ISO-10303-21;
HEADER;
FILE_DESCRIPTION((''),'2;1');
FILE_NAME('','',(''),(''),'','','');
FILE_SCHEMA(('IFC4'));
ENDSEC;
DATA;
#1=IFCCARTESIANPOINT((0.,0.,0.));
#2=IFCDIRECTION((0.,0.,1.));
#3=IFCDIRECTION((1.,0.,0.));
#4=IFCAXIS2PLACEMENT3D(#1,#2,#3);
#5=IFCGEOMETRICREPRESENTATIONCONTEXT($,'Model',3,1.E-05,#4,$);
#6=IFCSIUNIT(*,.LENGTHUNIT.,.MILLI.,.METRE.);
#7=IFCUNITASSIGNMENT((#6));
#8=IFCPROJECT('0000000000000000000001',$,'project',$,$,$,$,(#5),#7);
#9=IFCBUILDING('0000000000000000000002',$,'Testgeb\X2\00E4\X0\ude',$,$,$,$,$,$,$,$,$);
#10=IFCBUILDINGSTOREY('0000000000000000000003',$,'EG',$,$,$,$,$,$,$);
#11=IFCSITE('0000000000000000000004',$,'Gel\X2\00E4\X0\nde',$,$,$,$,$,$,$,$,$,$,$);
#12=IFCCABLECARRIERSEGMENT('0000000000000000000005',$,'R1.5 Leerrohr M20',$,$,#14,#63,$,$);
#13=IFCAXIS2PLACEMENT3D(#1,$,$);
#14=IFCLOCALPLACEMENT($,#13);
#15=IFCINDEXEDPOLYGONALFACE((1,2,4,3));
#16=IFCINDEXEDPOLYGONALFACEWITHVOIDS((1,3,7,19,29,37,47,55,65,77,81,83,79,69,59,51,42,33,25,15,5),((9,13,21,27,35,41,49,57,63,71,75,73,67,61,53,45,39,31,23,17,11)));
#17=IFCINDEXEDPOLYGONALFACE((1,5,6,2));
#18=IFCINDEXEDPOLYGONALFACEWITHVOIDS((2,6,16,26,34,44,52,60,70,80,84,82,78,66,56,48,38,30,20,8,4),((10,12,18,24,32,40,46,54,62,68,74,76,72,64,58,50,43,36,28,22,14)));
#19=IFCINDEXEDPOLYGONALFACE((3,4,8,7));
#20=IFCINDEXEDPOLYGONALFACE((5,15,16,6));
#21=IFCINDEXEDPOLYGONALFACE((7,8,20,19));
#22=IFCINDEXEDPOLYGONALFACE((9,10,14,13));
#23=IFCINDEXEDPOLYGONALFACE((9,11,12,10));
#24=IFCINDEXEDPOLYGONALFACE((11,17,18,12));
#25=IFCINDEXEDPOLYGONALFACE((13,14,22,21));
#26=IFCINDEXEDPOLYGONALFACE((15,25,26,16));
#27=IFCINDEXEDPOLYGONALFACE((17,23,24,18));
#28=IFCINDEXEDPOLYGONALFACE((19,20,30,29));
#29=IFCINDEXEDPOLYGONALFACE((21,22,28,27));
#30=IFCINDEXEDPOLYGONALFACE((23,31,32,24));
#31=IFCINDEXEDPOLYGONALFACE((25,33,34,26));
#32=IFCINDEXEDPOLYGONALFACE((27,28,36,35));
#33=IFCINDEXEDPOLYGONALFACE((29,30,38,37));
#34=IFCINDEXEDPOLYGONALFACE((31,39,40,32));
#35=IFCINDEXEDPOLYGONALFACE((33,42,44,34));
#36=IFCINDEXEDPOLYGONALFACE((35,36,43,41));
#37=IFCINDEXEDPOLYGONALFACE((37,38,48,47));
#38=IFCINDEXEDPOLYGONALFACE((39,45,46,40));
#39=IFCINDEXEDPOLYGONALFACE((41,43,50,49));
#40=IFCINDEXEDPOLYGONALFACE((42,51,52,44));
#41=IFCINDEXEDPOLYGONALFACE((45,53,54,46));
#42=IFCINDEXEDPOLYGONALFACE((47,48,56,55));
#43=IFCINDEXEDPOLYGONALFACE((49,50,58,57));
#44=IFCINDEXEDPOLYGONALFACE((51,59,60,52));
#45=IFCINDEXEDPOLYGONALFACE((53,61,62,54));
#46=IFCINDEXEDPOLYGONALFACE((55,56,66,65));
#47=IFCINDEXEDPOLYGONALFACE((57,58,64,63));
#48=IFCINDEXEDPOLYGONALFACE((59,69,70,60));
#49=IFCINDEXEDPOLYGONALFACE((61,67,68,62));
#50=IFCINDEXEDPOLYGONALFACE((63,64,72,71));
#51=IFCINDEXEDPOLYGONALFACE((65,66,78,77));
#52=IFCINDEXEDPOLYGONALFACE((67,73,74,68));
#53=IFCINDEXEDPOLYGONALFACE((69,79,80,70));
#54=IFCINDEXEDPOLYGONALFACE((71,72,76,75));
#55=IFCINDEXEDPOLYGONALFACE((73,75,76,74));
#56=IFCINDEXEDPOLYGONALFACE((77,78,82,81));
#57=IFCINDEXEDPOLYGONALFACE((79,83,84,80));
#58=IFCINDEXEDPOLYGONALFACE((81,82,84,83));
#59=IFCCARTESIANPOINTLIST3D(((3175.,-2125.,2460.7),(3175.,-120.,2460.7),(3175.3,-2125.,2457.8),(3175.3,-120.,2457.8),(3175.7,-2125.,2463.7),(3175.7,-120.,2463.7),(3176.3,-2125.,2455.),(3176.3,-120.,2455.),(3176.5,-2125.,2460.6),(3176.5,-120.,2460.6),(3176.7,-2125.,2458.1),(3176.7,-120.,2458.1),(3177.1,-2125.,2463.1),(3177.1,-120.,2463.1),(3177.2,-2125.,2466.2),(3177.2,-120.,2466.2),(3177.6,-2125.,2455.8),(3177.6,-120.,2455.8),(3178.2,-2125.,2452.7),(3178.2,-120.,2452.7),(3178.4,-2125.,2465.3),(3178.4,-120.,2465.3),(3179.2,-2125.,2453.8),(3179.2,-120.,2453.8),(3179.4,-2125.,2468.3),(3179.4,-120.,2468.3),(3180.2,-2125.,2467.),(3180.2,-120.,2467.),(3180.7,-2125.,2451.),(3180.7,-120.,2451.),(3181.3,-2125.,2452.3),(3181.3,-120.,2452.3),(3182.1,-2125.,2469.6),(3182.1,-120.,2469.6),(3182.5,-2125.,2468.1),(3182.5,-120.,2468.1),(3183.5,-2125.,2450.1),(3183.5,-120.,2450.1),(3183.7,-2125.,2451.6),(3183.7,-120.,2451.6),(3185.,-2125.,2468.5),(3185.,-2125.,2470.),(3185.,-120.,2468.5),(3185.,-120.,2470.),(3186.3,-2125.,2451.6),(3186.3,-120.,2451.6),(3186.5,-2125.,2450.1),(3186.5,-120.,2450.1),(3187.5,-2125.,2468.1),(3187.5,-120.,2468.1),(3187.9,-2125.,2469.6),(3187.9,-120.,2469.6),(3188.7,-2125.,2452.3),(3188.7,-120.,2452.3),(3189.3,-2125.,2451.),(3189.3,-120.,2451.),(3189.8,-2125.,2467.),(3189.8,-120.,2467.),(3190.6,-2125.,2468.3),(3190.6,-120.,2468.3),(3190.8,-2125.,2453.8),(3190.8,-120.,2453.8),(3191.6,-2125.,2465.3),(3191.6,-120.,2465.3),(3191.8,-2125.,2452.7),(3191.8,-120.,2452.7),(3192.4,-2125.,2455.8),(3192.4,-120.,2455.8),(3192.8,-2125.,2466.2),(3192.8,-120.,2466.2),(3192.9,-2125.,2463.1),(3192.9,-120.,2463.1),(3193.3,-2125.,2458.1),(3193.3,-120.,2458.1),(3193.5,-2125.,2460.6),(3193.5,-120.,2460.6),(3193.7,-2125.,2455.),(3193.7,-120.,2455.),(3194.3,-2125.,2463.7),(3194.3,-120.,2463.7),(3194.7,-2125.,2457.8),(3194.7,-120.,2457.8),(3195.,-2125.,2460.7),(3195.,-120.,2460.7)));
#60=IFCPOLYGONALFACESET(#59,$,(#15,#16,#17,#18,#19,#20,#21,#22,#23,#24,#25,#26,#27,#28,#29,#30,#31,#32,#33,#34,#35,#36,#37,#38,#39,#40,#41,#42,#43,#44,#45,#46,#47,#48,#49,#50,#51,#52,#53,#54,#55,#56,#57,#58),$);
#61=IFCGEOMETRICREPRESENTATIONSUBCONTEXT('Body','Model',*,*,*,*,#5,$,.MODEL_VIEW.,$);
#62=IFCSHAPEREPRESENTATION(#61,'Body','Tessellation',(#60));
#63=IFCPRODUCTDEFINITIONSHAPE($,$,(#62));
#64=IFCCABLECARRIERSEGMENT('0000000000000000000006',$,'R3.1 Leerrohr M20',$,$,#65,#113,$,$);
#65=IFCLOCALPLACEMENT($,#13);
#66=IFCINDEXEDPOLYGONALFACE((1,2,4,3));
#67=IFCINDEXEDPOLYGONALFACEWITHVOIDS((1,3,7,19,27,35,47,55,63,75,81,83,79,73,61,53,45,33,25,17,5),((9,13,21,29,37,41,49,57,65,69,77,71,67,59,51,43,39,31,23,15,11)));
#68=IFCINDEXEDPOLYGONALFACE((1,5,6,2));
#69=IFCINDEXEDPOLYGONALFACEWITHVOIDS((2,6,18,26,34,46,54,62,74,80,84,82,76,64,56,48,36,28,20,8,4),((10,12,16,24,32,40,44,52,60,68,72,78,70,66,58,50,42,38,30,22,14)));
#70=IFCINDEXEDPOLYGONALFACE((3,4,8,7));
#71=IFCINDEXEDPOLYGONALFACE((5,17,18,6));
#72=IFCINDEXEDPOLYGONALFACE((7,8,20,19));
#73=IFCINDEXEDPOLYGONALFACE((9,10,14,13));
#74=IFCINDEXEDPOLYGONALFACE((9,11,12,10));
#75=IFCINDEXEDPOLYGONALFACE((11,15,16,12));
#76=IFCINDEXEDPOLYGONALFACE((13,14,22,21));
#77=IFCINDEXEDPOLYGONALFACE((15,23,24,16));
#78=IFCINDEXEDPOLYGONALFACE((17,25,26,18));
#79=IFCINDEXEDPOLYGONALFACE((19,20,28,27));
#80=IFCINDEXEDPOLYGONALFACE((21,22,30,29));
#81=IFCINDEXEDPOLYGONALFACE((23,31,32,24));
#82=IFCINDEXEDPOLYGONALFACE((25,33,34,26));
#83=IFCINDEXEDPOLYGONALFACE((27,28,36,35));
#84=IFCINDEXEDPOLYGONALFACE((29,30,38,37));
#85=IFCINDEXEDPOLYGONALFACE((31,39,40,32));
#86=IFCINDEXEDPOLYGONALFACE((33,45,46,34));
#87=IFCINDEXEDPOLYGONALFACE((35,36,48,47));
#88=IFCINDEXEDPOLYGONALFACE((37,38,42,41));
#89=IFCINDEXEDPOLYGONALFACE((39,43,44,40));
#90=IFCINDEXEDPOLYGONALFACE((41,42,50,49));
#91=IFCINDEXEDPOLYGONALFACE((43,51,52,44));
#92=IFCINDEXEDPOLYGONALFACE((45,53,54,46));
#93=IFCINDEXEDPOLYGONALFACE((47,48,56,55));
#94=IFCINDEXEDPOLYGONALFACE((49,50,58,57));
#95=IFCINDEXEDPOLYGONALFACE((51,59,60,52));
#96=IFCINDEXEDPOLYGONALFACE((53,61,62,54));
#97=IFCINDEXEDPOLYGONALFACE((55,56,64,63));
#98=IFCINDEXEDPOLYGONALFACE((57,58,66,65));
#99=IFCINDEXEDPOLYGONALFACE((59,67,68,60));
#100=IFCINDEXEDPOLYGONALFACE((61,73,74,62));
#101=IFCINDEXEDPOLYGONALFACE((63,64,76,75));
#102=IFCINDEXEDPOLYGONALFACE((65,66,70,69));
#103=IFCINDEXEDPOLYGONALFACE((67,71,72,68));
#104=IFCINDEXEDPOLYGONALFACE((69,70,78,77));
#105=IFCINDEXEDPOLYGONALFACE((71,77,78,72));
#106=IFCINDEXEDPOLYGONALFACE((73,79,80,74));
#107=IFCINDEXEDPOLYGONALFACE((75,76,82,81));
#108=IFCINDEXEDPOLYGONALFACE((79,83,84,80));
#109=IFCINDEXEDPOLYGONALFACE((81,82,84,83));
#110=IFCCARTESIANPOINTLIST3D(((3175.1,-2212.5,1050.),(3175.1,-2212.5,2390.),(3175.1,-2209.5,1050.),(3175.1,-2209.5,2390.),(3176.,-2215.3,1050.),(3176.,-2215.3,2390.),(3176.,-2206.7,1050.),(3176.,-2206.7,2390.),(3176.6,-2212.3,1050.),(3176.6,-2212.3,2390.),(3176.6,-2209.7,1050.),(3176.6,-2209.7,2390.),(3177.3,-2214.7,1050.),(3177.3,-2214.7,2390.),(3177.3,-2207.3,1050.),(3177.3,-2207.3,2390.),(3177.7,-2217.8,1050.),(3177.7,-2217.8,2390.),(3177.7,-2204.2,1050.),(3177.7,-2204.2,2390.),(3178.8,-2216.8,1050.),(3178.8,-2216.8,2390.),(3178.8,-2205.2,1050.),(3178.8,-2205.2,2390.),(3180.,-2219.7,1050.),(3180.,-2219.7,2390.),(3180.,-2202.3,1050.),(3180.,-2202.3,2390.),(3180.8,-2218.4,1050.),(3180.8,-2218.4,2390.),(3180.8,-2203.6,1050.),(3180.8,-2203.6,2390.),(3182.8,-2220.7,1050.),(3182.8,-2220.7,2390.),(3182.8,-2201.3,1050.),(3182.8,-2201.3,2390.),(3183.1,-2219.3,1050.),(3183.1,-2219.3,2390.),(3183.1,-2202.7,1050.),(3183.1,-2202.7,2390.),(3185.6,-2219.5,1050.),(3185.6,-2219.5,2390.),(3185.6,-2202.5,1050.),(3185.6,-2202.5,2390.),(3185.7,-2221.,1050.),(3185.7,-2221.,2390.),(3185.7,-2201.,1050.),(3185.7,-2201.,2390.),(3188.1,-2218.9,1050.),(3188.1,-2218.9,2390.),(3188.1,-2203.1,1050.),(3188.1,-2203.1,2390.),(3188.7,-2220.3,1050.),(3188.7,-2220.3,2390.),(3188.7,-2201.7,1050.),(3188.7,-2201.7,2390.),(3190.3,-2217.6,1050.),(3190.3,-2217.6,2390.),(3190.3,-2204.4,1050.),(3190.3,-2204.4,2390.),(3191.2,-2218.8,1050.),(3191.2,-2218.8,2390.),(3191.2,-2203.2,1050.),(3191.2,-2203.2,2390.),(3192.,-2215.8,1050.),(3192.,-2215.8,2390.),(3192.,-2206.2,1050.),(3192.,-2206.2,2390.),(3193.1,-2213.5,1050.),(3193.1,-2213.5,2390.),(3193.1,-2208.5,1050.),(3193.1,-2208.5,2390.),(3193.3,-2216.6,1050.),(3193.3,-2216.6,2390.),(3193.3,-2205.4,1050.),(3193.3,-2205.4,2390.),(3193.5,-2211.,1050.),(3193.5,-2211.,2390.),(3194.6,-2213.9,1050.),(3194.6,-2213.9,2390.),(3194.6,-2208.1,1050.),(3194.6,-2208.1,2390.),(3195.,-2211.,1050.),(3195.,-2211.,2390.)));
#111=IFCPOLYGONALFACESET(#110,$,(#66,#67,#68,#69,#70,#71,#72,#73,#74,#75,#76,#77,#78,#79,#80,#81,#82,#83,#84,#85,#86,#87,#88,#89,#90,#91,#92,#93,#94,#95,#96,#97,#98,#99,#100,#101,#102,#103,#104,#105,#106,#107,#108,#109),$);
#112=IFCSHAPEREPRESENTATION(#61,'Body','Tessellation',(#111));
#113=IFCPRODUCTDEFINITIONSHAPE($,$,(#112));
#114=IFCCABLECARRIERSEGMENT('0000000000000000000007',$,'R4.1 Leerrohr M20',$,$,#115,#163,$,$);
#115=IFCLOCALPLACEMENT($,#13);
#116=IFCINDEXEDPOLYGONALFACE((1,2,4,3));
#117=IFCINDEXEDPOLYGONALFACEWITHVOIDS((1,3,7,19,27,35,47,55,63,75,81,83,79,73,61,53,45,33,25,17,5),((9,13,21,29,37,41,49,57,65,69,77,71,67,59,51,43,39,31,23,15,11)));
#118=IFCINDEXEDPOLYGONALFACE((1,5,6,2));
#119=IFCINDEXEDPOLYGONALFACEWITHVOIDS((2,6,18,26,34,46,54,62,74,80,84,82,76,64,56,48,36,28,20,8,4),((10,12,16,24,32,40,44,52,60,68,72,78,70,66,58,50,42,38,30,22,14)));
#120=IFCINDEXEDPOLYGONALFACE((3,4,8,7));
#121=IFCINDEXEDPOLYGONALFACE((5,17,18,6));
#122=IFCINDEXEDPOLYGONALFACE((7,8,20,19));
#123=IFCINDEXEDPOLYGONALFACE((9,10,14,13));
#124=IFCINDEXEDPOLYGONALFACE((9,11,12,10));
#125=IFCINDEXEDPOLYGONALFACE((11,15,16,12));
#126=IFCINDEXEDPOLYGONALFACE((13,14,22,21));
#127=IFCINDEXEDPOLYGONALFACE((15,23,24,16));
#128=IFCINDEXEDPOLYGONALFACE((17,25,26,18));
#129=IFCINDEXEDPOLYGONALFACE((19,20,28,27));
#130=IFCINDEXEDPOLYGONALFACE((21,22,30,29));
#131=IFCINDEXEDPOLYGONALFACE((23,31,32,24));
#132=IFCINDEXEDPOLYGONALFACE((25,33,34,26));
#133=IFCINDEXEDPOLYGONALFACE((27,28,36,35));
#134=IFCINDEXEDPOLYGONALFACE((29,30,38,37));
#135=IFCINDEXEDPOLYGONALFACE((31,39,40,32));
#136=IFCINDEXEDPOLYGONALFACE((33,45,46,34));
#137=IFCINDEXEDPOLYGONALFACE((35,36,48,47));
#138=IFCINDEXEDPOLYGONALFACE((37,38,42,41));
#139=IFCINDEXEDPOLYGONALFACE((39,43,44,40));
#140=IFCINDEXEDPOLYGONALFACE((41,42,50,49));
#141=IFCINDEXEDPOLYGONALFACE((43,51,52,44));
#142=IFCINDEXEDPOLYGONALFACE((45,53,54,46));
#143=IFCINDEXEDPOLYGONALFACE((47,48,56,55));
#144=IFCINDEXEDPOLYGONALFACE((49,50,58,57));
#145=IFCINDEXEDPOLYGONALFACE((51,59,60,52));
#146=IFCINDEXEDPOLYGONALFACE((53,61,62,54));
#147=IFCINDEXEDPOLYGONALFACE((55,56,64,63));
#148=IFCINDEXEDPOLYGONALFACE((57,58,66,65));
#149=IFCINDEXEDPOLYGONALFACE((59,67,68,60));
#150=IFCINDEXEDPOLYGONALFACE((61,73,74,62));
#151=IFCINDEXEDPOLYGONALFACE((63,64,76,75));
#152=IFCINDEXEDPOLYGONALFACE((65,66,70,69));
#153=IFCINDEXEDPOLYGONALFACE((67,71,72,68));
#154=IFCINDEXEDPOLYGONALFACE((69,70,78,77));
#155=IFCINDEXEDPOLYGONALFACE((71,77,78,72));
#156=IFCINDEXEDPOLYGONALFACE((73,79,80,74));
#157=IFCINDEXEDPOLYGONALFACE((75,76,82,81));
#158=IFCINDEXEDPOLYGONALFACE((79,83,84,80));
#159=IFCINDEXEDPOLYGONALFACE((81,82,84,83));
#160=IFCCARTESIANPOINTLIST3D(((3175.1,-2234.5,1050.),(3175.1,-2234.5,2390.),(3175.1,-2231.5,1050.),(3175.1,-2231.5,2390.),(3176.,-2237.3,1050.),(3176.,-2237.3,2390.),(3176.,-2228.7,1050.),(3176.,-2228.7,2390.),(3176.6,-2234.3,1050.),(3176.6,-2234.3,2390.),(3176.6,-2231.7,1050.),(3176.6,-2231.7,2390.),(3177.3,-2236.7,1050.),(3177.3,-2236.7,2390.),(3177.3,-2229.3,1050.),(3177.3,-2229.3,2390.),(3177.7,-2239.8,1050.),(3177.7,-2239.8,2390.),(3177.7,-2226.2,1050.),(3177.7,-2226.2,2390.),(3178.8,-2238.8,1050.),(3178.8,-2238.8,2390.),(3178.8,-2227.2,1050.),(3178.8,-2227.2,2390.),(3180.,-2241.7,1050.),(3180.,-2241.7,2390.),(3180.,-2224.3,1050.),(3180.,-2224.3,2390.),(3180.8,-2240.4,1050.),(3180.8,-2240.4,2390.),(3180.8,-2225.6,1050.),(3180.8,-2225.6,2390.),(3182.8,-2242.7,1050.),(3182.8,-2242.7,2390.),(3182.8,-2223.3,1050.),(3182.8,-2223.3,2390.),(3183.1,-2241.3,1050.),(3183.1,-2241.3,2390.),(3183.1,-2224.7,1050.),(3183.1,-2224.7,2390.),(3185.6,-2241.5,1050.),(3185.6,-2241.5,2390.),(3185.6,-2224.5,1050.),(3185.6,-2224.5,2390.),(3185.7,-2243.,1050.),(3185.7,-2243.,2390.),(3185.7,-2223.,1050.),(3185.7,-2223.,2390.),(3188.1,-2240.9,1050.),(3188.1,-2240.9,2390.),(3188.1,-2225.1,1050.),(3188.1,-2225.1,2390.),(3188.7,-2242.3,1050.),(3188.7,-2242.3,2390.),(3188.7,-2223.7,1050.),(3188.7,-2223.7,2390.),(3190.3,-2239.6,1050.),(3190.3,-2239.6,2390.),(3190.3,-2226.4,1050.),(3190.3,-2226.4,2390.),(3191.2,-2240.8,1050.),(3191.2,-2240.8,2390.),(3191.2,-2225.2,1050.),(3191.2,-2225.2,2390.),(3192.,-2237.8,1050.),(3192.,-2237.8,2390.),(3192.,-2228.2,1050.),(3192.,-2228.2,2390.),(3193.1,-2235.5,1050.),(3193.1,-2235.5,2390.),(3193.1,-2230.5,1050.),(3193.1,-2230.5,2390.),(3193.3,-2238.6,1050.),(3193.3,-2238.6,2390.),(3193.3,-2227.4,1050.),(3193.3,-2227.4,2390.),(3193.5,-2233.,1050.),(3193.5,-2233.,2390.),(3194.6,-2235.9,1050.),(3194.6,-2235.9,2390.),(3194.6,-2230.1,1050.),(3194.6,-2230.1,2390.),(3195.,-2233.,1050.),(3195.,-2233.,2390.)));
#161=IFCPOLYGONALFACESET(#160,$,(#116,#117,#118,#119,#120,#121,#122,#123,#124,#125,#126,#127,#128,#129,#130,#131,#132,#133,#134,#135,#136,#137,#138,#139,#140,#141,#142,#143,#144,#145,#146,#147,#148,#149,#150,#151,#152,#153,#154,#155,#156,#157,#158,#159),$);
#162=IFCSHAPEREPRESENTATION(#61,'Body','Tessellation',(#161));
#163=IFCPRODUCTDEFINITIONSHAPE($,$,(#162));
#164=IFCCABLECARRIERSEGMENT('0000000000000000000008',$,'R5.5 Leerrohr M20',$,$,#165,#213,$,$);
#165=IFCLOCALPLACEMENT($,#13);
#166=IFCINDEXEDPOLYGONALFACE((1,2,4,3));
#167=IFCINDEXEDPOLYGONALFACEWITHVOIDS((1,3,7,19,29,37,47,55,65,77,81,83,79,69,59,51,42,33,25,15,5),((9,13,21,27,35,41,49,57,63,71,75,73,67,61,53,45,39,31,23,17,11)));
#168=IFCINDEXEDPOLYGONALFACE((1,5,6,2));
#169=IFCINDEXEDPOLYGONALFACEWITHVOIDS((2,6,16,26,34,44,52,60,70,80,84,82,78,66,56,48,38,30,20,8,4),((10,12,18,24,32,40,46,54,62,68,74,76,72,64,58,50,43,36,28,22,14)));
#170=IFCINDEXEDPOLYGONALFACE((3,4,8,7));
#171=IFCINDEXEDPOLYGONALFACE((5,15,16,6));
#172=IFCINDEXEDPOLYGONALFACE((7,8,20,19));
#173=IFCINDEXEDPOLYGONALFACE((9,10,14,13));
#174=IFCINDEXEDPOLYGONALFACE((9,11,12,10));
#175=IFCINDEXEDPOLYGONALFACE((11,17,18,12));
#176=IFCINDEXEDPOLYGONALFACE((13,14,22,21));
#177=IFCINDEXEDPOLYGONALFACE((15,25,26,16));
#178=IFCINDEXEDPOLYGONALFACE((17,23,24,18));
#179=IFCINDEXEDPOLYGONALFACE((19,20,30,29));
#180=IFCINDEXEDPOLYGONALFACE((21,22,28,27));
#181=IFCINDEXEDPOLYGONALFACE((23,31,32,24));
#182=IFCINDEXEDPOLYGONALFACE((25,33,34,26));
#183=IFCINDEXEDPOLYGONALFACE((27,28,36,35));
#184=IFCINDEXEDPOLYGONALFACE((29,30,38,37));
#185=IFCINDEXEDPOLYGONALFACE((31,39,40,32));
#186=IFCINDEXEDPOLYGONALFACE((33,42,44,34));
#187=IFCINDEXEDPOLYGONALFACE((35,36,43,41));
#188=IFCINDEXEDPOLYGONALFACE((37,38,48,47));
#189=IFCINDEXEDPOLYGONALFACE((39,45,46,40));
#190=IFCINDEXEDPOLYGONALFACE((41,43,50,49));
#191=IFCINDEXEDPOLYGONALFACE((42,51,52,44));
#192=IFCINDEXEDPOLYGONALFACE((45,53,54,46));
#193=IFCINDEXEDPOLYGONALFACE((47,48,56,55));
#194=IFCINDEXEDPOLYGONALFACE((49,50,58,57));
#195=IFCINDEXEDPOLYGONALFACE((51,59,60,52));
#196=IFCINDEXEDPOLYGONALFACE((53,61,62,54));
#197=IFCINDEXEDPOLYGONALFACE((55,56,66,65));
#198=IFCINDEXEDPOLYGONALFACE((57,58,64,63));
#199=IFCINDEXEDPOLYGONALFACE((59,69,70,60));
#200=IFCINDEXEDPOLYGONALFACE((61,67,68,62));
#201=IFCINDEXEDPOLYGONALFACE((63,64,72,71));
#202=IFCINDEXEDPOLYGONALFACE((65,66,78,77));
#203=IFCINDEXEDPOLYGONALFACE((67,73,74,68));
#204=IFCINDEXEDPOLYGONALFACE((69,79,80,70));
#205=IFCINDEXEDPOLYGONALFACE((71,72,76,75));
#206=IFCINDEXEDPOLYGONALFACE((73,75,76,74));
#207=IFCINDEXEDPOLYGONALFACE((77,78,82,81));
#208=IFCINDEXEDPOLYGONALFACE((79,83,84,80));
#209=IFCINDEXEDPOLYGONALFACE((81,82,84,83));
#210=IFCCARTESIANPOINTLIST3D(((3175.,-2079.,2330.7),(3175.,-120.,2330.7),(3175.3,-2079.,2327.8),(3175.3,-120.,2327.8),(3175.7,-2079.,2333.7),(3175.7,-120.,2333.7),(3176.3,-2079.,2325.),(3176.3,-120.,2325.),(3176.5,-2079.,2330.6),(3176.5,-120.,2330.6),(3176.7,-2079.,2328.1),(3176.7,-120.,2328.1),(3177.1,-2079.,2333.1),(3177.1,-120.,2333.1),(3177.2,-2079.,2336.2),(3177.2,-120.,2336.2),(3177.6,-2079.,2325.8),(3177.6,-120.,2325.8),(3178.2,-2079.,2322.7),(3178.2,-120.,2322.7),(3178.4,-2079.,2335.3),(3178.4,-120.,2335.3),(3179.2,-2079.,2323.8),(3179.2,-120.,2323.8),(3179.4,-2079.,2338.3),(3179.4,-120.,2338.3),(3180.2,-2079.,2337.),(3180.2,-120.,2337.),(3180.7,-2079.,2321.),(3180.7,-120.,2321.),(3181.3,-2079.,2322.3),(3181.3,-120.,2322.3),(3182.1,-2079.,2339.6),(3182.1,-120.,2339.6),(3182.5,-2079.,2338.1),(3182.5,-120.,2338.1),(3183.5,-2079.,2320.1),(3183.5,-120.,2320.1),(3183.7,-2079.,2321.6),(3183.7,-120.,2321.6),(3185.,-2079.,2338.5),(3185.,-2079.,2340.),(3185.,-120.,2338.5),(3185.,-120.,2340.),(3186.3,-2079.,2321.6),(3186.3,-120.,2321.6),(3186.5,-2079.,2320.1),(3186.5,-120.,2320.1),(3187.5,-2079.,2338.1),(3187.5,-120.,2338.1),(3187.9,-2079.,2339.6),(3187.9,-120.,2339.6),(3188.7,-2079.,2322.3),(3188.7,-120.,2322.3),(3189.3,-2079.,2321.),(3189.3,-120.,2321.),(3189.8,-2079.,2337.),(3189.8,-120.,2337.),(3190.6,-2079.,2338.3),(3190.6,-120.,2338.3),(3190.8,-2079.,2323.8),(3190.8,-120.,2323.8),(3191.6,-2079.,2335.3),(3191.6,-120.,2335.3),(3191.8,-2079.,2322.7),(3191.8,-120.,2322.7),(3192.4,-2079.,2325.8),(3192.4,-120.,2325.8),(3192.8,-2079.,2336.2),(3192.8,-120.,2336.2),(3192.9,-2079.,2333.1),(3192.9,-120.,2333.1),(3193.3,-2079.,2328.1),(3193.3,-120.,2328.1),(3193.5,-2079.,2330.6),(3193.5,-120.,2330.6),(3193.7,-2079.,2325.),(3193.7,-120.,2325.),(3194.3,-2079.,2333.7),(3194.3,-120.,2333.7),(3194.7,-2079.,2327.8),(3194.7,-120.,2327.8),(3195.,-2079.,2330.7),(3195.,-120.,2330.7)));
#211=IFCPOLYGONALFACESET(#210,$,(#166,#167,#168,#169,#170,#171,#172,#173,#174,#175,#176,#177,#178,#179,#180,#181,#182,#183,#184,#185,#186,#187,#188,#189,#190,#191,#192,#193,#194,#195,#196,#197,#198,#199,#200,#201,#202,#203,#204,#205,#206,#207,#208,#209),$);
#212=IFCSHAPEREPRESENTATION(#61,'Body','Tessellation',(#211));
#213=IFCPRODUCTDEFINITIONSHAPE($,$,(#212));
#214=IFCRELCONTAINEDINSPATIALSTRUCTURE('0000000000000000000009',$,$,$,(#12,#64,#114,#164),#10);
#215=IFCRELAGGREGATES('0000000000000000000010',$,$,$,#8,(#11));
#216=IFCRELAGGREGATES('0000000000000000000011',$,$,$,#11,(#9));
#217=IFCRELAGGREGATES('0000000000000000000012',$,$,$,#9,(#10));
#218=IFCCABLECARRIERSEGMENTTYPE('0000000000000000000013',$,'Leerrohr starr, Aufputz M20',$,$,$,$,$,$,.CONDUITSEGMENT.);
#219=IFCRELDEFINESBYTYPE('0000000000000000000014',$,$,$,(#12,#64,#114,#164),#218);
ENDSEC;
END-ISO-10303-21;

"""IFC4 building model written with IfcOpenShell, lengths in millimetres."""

from ifc_helpers import new_model, si_unit, frame, origin_with_axes, place, context, subcontext, project, spatial, hollow_circle, extrude, type_object, element, save


model = new_model("IFC4")

# Units and contexts
model_context = context("Model", 3, precision=1e-05, world=origin_with_axes())
body_context = subcontext(model_context, "Body", "Model", "MODEL_VIEW")
ifc_project = project(units=[si_unit("LENGTHUNIT", "METRE", prefix="MILLI")], contexts=[model_context])

# Site, building, storey
site = spatial("IfcSite", under=ifc_project, Name="Gelände")
building = spatial("IfcBuilding", under=site, Name="Testgebäude")
storey = spatial("IfcBuildingStorey", under=building, Name="EG")

# Cable carrier segments
cable_carrier_segment_type_1 = type_object("IfcCableCarrierSegmentType", Name="Leerrohr starr, Aufputz M20", PredefinedType="CONDUITSEGMENT")
cable_carrier_segment_1_placement = place(None, frame((3185.0, -120.0, 2460.0), z_axis=(0.0, -1.0, 0.0), x_axis=(0.0, 0.0, 1.0)))
element("IfcCableCarrierSegment", 1, at=cable_carrier_segment_1_placement, inside=storey, type_object=cable_carrier_segment_type_1, Name="R1.5 Leerrohr M20", context=body_context, shape_type="SweptSolid", body=[
    extrude(hollow_circle(Radius=10.0, WallThickness=1.5), None, (0.0, 0.0, 1.0), 2005.0),
])
for number, where, z_axis, x_axis, name in (
    (2, (3185.0, -2211.0, 1050.0), (0.0, 0.0, 1.0), (1.0, 0.0, 0.0), "R3.1 Leerrohr M20"),
    (3, (3185.0, -2233.0, 1050.0), (0.0, 0.0, 1.0), (1.0, 0.0, 0.0), "R4.1 Leerrohr M20"),
):
    element("IfcCableCarrierSegment", number, at=place(None, frame(where, z_axis=z_axis, x_axis=x_axis)), inside=storey, type_object=cable_carrier_segment_type_1, Name=name, context=body_context, shape_type="SweptSolid", body=[
        extrude(hollow_circle(Radius=10.0, WallThickness=1.5), None, (0.0, 0.0, 1.0), 1340.0),
    ])
cable_carrier_segment_2_placement = place(None, frame((3185.0, -120.0, 2330.0), z_axis=(0.0, -1.0, 0.0), x_axis=(0.0, 0.0, 1.0)))
element("IfcCableCarrierSegment", 4, at=cable_carrier_segment_2_placement, inside=storey, type_object=cable_carrier_segment_type_1, Name="R5.5 Leerrohr M20", context=body_context, shape_type="SweptSolid", body=[
    extrude(hollow_circle(Radius=10.0, WallThickness=1.5), None, (0.0, 0.0, 1.0), 1959.0),
])

save(model, "model.ifc")
